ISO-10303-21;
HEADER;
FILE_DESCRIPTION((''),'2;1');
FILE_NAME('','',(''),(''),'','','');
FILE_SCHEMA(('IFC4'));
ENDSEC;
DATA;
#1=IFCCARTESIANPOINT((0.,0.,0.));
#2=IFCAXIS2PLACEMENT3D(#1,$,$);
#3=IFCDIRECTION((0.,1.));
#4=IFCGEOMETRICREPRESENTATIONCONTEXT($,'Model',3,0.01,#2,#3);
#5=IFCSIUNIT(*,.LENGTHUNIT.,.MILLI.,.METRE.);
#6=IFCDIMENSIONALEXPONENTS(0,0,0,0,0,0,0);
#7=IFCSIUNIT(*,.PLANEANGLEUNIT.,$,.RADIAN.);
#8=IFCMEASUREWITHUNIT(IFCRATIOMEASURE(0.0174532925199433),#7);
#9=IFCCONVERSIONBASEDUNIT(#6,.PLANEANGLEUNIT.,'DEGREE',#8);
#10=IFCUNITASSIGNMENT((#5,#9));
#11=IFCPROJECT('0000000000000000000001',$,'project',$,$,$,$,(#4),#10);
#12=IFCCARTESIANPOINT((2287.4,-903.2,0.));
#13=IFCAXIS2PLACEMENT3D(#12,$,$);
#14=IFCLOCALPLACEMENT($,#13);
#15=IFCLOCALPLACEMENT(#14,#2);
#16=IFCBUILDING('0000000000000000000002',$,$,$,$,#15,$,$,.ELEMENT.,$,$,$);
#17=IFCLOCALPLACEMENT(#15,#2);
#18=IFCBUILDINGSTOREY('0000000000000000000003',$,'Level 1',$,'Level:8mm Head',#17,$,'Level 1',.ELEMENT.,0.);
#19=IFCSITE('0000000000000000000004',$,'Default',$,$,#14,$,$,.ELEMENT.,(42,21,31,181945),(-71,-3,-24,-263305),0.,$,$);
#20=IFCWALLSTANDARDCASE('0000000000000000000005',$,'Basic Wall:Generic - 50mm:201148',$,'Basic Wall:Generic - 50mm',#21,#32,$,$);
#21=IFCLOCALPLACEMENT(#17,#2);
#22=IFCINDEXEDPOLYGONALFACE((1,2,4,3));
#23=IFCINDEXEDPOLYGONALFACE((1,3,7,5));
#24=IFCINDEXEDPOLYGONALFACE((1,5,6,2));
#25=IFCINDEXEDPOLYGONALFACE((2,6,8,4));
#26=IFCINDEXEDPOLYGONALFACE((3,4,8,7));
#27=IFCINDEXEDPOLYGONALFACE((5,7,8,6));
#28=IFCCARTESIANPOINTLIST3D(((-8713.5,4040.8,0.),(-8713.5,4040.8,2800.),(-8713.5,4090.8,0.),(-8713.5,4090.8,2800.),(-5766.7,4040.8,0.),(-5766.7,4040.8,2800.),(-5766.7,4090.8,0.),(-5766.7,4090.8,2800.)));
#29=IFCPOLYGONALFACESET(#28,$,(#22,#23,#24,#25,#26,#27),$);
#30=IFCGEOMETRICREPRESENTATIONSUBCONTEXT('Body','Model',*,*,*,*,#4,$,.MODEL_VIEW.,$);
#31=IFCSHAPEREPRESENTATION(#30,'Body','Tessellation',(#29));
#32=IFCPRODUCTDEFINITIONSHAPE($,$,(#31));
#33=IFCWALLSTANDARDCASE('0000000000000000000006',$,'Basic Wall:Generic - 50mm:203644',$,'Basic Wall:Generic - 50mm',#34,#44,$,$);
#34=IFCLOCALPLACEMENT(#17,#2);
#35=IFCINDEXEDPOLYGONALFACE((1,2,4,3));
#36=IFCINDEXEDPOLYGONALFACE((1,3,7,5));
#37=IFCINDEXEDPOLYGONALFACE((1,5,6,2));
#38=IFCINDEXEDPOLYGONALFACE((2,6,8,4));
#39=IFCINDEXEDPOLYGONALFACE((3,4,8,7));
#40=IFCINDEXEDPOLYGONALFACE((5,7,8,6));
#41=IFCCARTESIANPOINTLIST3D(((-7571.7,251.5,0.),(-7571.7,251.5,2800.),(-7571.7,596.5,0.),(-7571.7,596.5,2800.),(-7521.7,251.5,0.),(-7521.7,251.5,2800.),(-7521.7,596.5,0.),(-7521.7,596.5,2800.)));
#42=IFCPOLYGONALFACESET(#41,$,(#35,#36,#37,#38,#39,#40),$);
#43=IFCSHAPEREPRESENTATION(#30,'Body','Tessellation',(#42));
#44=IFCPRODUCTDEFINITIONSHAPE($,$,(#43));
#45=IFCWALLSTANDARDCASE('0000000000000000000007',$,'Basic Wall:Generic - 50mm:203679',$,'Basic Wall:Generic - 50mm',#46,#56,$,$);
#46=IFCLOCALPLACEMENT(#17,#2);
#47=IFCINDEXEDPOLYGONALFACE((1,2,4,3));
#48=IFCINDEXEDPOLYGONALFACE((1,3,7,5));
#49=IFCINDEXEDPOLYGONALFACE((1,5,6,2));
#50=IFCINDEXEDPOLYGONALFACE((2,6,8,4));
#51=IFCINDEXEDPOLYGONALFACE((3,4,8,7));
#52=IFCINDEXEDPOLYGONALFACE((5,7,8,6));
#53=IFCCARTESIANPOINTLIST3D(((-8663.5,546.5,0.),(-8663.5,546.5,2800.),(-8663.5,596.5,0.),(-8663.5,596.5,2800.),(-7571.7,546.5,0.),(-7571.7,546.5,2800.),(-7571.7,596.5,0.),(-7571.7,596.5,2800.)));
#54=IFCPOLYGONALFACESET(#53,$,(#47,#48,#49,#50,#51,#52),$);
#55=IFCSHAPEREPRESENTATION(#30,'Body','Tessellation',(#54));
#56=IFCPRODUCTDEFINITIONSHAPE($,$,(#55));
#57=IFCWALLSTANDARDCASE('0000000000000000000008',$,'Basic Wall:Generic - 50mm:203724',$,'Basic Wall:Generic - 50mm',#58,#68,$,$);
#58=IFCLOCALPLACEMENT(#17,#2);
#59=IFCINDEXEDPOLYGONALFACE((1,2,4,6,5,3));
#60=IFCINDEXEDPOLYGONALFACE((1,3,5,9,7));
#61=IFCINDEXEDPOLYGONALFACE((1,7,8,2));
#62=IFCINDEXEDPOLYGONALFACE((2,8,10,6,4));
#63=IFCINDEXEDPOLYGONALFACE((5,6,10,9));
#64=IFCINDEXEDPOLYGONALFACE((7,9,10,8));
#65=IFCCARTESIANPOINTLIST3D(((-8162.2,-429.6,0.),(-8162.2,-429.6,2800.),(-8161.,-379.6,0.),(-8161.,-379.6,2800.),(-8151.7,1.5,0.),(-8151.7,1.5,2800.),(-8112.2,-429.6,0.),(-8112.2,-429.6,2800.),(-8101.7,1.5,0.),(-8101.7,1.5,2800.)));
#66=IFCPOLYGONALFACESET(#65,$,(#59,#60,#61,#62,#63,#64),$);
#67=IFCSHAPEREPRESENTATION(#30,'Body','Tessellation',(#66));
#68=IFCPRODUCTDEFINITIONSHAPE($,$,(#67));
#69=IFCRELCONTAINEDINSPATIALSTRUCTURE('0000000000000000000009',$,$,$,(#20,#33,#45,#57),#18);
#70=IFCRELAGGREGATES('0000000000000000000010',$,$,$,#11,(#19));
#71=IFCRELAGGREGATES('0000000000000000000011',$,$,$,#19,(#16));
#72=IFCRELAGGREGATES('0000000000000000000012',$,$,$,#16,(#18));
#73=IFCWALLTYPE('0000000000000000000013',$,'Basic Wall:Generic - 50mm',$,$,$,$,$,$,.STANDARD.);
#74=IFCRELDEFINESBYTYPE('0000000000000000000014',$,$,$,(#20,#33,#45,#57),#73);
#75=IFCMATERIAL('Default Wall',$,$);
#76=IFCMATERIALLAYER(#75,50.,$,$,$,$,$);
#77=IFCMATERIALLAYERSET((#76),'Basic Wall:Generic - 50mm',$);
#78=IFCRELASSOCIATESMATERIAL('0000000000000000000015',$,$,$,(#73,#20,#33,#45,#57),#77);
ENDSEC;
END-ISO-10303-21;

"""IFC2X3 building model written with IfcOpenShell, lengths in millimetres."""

from ifc_helpers import new_model, entity, si_unit, converted_unit, direction, frame, frame_2d, origin, place, context, subcontext, project, spatial, polyline, rectangle, outline, extrude, material, layer, layer_set, layer_usage, type_object, element, save


model = new_model("IFC2X3")

# Units and contexts
model_context = context("Model", 3, precision=0.01, world=origin(), true_north=direction((0.0, 1.0)))
body_context = subcontext(model_context, "Body", "Model", "MODEL_VIEW")
ifc_project = project(units=[si_unit("LENGTHUNIT", "METRE", prefix="MILLI"), converted_unit("PLANEANGLEUNIT", "DEGREE", entity("IfcRatioMeasure", 0.0174532925199433), si_unit("PLANEANGLEUNIT", "RADIAN"), dimensions=[0, 0, 0, 0, 0, 0, 0])], contexts=[model_context])

# Site, building, storey
site_placement = place(None, frame((2287.4, -903.2, 0.0)))
site = spatial("IfcSite", under=ifc_project, at=site_placement, Name="Default", CompositionType="ELEMENT", RefLatitude=(42, 21, 31, 181945), RefLongitude=(-71, -3, -24, -263305), RefElevation=0.0)
building_placement = place(site_placement, origin())
building = spatial("IfcBuilding", under=site, at=building_placement, CompositionType="ELEMENT")
storey_placement = place(building_placement, origin())
storey = spatial("IfcBuildingStorey", under=building, at=storey_placement, Name="Level 1", ObjectType="Level:8mm Head", LongName="Level 1", CompositionType="ELEMENT", Elevation=0.0)

# Walls
ifc_material_1 = material(Name="Default Wall")
ifc_layer = layer(ifc_material_1, 50.0)
ifc_layer_set = layer_set([ifc_layer], Name="Basic Wall:Generic - 50mm")
ifc_layer_usage_1 = layer_usage(ifc_layer_set, "AXIS2", "NEGATIVE", 25.0)
wall_type = type_object("IfcWallType", Name="Basic Wall:Generic - 50mm", PredefinedType="STANDARD", material=ifc_layer_set)
wall_1_placement = place(storey_placement, frame((-8713.5, 4065.8, 0.0)))
element("IfcWallStandardCase", 1, at=wall_1_placement, inside=storey, type_object=wall_type, material=ifc_layer_usage_1, Name="Basic Wall:Generic - 50mm:201148", ObjectType="Basic Wall:Generic - 50mm", context=body_context, shape_type="SweptSolid", body=[
    extrude(rectangle(XDim=2946.8, YDim=50.0, at=frame_2d((1473.4, 0.0), x_axis=(-1.0, 0.0))), origin(), (0.0, 0.0, 1.0), 2800.0),
])
ifc_layer_usage_2 = layer_usage(ifc_layer_set, "AXIS2", "POSITIVE", -25.0)
wall_2_placement = place(storey_placement, frame((-7546.7, 251.5, 0.0), z_axis=(0.0, 0.0, 1.0), x_axis=(0.0, 1.0, 0.0)))
element("IfcWallStandardCase", 2, at=wall_2_placement, inside=storey, type_object=wall_type, material=ifc_layer_usage_2, Name="Basic Wall:Generic - 50mm:203644", ObjectType="Basic Wall:Generic - 50mm", context=body_context, shape_type="SweptSolid", body=[
    extrude(rectangle(XDim=345.0, YDim=50.0, at=frame_2d((172.5, 0.0), x_axis=(-1.0, 0.0))), origin(), (0.0, 0.0, 1.0), 2800.0),
])
ifc_layer_usage_3 = layer_usage(ifc_layer_set, "AXIS2", "POSITIVE", -25.0)
wall_3_placement = place(storey_placement, frame((-7571.7, 571.5, 0.0), z_axis=(0.0, 0.0, 1.0), x_axis=(-1.0, 0.0, 0.0)))
element("IfcWallStandardCase", 3, at=wall_3_placement, inside=storey, type_object=wall_type, material=ifc_layer_usage_3, Name="Basic Wall:Generic - 50mm:203679", ObjectType="Basic Wall:Generic - 50mm", context=body_context, shape_type="SweptSolid", body=[
    extrude(rectangle(XDim=1091.8, YDim=50.0, at=frame_2d((545.9, 0.0), x_axis=(-1.0, 0.0))), origin(), (0.0, 0.0, 1.0), 2800.0),
])
ifc_layer_usage_4 = layer_usage(ifc_layer_set, "AXIS2", "NEGATIVE", 25.0)
wall_4_placement = place(storey_placement, frame((-8126.7, 2.1, 0.0), z_axis=(0.0, 0.0, 1.0), x_axis=(-0.024354, -0.999703, 0.0)))
element("IfcWallStandardCase", 4, at=wall_4_placement, inside=storey, type_object=wall_type, material=ifc_layer_usage_4, Name="Basic Wall:Generic - 50mm:203724", ObjectType="Basic Wall:Generic - 50mm", context=body_context, shape_type="SweptSolid", body=[
    extrude(outline(polyline([(432.5, -25.0), (431.2, 25.0), (0.0, 25.0), (1.2, -25.0), (382.4, -25.0), (432.5, -25.0)])), origin(), (0.0, 0.0, 1.0), 2800.0),
])

save(model, "model.ifc")
